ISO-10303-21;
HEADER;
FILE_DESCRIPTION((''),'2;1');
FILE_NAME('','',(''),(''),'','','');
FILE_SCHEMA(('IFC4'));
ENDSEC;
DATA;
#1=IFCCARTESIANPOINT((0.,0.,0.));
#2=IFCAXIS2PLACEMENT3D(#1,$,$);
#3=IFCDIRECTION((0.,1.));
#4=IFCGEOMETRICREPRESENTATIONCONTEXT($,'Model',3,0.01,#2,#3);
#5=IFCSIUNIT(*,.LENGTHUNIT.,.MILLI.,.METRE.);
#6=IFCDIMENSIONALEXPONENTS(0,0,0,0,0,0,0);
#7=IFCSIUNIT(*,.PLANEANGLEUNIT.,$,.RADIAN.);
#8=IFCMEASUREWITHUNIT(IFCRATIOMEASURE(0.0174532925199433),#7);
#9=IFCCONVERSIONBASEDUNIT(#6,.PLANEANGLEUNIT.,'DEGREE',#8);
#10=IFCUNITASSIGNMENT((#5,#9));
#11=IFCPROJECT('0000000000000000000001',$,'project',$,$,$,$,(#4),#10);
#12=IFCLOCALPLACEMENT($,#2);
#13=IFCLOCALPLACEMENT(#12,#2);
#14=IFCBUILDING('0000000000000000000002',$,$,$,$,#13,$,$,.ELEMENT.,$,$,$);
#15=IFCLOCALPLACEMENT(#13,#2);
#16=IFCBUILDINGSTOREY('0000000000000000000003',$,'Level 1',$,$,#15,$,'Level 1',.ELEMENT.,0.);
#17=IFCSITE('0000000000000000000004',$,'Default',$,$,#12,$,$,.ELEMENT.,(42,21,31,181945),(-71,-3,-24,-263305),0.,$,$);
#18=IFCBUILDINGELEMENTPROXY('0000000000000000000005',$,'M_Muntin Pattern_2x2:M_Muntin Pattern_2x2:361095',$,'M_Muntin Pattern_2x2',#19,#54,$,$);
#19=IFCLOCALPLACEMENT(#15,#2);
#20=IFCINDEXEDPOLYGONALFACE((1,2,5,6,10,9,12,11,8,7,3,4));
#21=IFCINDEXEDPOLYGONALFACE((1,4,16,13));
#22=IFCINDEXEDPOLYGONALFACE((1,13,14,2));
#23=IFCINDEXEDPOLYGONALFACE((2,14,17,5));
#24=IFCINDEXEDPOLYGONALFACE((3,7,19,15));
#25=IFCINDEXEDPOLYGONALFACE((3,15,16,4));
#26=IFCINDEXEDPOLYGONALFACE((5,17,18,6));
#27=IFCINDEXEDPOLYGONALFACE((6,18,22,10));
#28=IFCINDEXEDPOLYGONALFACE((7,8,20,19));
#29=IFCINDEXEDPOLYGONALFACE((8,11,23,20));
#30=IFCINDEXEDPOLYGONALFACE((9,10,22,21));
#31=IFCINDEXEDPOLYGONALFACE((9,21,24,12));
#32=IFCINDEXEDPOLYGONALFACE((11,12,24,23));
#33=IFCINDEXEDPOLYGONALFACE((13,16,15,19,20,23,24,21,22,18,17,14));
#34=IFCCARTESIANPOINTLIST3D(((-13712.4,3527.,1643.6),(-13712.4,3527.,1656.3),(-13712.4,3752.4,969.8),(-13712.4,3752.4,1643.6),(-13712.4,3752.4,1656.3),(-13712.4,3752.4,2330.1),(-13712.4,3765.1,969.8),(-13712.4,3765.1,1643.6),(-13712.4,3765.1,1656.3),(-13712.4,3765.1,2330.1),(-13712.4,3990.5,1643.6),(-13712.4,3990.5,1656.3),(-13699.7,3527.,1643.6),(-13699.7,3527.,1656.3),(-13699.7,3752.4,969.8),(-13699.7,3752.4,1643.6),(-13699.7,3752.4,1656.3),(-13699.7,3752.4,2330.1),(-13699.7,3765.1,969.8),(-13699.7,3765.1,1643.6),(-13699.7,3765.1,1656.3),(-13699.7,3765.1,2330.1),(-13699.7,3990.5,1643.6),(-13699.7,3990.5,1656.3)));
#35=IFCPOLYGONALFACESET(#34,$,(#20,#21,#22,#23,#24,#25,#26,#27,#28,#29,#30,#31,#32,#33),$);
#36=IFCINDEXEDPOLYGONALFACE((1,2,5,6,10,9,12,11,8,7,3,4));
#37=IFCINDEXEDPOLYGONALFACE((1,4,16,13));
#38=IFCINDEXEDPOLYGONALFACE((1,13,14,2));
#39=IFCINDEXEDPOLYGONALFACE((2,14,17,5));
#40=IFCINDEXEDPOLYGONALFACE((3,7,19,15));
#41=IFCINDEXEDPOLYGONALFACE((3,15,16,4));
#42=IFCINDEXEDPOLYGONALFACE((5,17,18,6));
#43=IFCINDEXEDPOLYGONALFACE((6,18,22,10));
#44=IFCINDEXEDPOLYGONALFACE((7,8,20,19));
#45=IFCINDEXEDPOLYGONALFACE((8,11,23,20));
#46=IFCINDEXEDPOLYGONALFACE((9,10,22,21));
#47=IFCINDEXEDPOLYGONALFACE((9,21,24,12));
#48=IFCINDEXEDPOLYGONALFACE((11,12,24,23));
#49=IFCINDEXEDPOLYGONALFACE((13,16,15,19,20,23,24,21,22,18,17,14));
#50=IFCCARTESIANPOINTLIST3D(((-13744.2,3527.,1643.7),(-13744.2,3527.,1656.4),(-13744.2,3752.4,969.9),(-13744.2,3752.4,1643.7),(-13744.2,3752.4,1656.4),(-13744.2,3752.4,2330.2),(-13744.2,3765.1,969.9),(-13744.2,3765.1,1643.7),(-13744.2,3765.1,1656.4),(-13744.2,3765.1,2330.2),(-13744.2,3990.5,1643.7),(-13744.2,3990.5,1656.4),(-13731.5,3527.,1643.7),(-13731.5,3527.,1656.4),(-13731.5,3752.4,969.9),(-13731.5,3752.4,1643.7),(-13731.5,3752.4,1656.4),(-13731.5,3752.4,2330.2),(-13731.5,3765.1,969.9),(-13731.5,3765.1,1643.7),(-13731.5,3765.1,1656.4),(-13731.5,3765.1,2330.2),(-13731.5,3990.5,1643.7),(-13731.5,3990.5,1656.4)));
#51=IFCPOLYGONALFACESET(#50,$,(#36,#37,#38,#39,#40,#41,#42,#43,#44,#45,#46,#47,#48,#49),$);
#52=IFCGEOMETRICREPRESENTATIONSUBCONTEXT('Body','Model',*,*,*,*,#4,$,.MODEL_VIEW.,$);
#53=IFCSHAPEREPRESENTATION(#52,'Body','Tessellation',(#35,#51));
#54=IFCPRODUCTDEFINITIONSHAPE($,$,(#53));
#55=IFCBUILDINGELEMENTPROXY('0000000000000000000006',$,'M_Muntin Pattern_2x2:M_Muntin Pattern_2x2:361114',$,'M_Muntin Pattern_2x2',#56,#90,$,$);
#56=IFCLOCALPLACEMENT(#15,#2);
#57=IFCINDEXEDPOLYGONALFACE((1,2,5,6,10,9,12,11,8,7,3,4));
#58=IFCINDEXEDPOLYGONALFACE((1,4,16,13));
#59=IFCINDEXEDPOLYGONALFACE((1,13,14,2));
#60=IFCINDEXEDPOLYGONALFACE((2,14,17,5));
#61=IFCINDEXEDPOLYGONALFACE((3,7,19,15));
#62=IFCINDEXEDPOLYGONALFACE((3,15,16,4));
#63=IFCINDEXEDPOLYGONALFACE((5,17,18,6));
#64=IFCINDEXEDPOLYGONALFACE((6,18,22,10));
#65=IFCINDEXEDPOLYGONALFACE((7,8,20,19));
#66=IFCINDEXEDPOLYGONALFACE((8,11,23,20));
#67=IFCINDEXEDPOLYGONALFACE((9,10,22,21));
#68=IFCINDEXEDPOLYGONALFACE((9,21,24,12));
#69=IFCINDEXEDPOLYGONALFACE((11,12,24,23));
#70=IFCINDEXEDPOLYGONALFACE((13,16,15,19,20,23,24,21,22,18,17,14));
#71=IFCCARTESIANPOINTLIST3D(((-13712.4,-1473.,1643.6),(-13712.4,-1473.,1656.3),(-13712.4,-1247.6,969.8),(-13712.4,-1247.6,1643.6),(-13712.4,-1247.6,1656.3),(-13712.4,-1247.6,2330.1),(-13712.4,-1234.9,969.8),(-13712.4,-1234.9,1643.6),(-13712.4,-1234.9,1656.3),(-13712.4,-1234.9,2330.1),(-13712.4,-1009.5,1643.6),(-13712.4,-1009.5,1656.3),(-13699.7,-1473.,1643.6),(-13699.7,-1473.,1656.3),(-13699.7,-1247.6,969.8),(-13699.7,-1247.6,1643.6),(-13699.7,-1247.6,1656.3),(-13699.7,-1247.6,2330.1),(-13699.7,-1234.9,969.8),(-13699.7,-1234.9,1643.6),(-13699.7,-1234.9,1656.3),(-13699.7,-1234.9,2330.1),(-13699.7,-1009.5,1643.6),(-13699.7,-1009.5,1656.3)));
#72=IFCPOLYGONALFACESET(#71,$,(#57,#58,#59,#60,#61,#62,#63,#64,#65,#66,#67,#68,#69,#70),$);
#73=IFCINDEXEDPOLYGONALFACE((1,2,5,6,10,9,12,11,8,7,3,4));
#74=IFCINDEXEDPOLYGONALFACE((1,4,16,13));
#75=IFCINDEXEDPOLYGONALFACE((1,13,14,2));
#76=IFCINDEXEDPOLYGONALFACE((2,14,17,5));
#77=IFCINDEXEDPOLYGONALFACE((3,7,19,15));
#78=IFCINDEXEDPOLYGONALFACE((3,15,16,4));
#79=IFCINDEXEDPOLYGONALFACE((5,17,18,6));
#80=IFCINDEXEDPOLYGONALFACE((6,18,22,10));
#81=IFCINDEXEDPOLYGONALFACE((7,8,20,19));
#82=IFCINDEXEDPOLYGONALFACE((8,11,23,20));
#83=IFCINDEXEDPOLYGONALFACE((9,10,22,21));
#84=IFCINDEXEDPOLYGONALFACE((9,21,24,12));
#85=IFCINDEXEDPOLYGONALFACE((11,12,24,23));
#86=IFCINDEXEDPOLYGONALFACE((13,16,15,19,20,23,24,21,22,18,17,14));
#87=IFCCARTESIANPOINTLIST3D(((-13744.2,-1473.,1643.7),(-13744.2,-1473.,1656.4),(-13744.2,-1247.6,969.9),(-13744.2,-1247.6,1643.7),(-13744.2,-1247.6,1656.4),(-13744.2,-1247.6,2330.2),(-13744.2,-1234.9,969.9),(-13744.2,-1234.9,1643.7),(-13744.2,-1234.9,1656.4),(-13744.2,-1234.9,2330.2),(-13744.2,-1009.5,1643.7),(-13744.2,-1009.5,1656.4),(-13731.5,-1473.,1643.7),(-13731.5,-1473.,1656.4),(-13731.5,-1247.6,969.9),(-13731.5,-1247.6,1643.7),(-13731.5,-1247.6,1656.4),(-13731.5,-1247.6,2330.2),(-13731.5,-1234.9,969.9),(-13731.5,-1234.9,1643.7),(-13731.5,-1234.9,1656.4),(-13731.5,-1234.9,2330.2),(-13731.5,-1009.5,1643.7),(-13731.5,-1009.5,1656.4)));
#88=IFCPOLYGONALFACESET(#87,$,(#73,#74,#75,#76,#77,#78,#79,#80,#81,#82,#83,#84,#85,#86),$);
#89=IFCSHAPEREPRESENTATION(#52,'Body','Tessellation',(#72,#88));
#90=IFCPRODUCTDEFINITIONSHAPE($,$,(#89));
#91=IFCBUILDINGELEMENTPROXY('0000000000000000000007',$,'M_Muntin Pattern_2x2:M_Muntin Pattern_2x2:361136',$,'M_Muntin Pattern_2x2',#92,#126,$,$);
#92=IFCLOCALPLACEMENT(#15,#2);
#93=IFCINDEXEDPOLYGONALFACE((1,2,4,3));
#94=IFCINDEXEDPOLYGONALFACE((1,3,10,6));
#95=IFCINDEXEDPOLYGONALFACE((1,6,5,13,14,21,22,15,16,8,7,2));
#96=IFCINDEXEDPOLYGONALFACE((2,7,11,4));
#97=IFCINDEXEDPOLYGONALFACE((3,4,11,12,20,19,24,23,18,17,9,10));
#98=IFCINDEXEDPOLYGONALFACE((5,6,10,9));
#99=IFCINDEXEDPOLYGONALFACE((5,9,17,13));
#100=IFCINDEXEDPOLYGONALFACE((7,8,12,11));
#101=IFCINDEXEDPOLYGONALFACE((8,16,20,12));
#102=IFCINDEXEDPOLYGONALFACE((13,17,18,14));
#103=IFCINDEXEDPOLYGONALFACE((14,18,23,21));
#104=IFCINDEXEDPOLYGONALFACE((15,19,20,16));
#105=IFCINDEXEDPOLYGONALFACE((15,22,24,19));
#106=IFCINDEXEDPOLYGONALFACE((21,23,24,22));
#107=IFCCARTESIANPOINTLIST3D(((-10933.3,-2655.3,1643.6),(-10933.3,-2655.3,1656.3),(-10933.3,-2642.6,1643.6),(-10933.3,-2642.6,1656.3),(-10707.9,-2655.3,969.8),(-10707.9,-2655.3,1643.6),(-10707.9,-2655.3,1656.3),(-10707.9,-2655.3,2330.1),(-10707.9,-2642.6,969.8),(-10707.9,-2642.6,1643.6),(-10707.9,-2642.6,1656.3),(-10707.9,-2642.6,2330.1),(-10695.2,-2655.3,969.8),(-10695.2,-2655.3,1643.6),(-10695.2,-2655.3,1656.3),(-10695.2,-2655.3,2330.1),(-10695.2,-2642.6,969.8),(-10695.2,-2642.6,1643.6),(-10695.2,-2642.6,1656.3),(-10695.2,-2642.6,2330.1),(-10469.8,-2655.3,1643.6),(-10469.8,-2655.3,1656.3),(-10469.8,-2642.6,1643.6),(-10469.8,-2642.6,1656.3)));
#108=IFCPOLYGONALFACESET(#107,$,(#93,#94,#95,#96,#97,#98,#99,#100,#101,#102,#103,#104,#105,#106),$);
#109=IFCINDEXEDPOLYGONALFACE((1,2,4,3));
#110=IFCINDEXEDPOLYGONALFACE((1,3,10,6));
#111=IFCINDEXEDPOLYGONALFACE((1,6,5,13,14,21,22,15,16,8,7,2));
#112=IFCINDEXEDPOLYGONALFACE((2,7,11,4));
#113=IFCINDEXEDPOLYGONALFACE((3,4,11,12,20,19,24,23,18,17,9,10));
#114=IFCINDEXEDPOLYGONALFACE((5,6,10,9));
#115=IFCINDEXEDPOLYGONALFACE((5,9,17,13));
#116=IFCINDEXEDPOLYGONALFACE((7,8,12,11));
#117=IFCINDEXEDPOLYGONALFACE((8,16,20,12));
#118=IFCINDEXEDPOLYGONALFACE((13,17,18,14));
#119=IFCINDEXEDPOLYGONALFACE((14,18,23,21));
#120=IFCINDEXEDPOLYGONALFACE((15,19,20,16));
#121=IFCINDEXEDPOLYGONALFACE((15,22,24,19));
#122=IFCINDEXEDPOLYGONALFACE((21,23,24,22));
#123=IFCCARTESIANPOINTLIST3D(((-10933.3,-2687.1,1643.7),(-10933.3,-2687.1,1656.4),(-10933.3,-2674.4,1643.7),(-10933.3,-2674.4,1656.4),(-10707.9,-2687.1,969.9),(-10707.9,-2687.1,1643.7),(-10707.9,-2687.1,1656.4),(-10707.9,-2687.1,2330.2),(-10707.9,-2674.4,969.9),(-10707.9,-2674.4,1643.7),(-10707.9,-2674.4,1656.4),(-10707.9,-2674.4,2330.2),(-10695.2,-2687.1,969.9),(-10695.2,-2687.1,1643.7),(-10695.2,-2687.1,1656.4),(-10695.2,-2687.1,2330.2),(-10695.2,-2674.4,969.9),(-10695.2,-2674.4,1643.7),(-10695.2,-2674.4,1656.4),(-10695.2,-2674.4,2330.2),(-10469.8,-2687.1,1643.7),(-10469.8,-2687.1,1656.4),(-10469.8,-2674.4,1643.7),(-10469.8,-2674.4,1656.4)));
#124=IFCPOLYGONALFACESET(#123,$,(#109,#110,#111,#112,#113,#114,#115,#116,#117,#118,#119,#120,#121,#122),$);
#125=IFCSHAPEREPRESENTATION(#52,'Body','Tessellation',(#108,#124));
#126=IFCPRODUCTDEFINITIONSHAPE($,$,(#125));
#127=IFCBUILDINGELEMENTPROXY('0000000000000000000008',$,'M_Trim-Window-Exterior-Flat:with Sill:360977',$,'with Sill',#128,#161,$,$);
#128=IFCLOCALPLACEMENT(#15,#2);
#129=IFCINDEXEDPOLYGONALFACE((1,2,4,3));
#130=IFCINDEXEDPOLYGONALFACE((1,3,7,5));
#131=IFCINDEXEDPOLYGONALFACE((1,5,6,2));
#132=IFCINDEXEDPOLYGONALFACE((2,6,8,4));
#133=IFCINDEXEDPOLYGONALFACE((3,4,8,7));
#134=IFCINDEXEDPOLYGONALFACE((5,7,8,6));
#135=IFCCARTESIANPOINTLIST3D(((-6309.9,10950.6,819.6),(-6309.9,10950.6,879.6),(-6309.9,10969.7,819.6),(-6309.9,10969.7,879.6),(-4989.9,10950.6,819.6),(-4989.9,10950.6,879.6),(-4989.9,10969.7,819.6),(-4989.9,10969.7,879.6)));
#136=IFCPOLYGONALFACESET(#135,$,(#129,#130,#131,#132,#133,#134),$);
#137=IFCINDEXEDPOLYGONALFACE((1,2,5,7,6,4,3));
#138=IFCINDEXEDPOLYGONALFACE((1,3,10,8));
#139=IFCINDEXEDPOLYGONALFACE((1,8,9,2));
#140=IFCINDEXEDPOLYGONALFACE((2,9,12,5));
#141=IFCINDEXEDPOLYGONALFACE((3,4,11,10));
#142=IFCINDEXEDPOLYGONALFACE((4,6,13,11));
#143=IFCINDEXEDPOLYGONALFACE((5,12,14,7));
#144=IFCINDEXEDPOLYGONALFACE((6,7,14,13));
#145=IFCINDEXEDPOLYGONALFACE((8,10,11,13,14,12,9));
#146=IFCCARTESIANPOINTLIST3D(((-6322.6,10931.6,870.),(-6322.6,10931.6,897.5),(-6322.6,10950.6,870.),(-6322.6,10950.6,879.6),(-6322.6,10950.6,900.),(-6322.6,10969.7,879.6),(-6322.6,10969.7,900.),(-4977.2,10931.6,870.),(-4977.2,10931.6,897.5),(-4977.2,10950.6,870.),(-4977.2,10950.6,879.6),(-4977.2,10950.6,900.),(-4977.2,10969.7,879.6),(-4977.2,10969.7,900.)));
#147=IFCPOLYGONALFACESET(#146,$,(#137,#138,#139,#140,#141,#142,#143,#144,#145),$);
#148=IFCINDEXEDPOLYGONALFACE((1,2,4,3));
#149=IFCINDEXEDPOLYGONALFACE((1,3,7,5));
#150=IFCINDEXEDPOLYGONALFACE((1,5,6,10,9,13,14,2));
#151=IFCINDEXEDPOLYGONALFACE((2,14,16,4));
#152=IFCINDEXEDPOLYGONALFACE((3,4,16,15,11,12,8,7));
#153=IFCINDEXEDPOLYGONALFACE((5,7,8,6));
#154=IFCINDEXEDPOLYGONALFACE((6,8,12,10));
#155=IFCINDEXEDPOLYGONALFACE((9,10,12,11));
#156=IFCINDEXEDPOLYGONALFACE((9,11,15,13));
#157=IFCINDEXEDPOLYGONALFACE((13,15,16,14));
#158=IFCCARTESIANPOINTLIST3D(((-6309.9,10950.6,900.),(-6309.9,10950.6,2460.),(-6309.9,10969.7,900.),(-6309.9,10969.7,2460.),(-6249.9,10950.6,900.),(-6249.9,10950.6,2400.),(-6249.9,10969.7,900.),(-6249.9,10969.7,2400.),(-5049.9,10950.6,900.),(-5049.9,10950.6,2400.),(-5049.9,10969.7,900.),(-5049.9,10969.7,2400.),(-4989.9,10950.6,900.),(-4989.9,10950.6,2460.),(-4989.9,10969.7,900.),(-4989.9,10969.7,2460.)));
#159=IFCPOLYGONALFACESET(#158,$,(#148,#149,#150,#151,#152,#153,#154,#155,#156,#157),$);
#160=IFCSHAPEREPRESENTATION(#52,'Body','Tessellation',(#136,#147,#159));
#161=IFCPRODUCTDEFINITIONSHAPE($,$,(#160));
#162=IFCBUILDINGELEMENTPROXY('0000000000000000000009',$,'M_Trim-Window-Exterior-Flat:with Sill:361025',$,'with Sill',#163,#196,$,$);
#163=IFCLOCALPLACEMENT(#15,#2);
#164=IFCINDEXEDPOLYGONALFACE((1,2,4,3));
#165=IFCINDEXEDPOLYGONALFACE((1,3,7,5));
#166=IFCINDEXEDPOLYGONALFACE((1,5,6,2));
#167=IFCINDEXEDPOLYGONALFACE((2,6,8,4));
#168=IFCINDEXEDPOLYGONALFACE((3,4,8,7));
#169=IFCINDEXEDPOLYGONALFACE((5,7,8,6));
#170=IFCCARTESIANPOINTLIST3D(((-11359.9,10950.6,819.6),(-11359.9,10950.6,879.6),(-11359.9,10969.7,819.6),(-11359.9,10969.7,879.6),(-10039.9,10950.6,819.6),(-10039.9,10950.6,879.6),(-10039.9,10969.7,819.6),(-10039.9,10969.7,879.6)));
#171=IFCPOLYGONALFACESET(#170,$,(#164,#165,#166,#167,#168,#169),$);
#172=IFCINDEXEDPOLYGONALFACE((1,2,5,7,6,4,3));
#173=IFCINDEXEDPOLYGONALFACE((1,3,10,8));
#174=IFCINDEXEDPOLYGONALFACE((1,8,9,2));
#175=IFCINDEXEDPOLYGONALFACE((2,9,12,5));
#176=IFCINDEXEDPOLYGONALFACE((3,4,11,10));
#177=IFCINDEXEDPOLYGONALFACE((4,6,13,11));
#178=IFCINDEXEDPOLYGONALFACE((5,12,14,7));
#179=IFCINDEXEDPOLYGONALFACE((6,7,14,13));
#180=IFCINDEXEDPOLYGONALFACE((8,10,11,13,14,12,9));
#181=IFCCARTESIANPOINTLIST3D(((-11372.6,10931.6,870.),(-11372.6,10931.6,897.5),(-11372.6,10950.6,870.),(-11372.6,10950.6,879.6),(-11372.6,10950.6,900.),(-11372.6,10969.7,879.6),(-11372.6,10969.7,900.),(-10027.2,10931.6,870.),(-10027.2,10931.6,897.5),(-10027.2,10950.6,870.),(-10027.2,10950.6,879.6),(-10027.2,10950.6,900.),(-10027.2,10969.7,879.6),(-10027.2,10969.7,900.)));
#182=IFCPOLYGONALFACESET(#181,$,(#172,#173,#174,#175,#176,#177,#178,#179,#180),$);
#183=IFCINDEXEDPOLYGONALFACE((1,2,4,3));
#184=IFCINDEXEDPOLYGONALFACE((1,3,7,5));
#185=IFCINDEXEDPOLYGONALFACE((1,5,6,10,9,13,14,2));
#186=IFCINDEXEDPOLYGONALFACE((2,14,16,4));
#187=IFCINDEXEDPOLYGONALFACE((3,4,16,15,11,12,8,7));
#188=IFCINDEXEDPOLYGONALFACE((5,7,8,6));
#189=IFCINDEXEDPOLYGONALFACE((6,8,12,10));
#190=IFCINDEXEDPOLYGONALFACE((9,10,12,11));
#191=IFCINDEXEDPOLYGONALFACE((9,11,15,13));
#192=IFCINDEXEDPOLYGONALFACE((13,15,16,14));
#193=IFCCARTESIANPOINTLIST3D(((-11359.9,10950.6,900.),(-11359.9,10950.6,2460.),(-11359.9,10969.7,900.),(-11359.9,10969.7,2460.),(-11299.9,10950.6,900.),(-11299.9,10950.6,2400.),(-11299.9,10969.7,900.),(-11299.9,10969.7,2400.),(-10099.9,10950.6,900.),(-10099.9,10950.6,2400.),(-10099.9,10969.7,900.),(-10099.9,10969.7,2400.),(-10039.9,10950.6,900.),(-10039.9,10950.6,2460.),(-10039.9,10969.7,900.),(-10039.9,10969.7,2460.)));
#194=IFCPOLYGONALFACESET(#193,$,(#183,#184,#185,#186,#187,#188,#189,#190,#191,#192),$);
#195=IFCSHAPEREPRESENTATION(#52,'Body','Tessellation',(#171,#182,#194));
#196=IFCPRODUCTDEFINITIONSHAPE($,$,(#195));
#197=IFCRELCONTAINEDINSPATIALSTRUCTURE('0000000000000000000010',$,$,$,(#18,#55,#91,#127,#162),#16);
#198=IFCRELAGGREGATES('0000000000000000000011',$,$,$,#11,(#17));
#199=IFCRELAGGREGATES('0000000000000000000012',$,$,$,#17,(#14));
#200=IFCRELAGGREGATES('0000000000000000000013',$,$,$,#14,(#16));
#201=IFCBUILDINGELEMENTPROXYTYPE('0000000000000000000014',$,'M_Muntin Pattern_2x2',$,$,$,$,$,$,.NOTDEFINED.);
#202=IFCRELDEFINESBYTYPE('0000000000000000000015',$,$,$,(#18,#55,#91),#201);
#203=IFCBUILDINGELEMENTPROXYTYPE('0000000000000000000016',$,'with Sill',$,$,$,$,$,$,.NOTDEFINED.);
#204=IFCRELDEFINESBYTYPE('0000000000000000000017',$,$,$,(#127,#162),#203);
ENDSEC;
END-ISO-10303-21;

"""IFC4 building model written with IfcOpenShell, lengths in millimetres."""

from ifc_helpers import new_model, entity, si_unit, converted_unit, direction, frame, frame_2d, origin, place, context, subcontext, project, spatial, polyline, rectangle, outline, extrude, source, transform, mapped, type_object, type_shapes, element, save


model = new_model("IFC4")

# Units and contexts
model_context = context("Model", 3, precision=0.01, world=origin(), true_north=direction((0.0, 1.0)))
body_context = subcontext(model_context, "Body", "Model", "MODEL_VIEW")
ifc_project = project(units=[si_unit("LENGTHUNIT", "METRE", prefix="MILLI"), converted_unit("PLANEANGLEUNIT", "DEGREE", entity("IfcRatioMeasure", 0.0174532925199433), si_unit("PLANEANGLEUNIT", "RADIAN"), dimensions=[0, 0, 0, 0, 0, 0, 0])], contexts=[model_context])

# Site, building, storey
site_placement = place(None, origin())
site = spatial("IfcSite", under=ifc_project, at=site_placement, Name="Default", CompositionType="ELEMENT", RefLatitude=(42, 21, 31, 181945), RefLongitude=(-71, -3, -24, -263305), RefElevation=0.0)
building_placement = place(site_placement, origin())
building = spatial("IfcBuilding", under=site, at=building_placement, CompositionType="ELEMENT")
storey_placement = place(building_placement, origin())
storey = spatial("IfcBuildingStorey", under=building, at=storey_placement, Name="Level 1", LongName="Level 1", CompositionType="ELEMENT", Elevation=0.0)

# Building element proxies
building_element_proxy_type_1 = type_object("IfcBuildingElementProxyType", Name="M_Muntin Pattern_2x2", PredefinedType="NOTDEFINED")
shared_shape_1 = source(origin(), body_context, "Body", "SweptSolid", [
    extrude(outline(polyline([(6.4, -6.4), (680.1, -6.4), (680.1, 6.3), (6.4, 6.3), (6.4, 231.7), (-6.3, 231.7), (-6.3, 6.3), (-680.2, 6.3), (-680.2, -6.4), (-6.3, -6.4), (-6.3, -231.7), (6.4, -231.7), (6.4, -6.4)])), frame((0.0, -22.2, 680.1), z_axis=(0.0, 1.0, 0.0), x_axis=(0.0, 0.0, 1.0)), (0.0, 0.0, 1.0), 12.7),
    extrude(outline(polyline([(6.4, -6.4), (680.1, -6.4), (680.1, 6.3), (6.4, 6.3), (6.4, 231.7), (-6.3, 231.7), (-6.3, 6.3), (-680.2, 6.3), (-680.2, -6.4), (-6.3, -6.4), (-6.3, -231.7), (6.4, -231.7), (6.4, -6.4)])), frame((0.0, 9.5, 680.2), z_axis=(0.0, 1.0, 0.0), x_axis=(0.0, 0.0, 1.0)), (0.0, 0.0, 1.0), 12.7),
])
type_shapes(building_element_proxy_type_1, [shared_shape_1])
for number, where, z_axis, x_axis, name in (
    (1, (-13722.0, 3758.7, 969.9), (0.0, 0.0, 1.0), (0.0, 1.0, 0.0), "M_Muntin Pattern_2x2:M_Muntin Pattern_2x2:361095"),
    (2, (-13722.0, -1241.3, 969.9), (0.0, 0.0, 1.0), (0.0, 1.0, 0.0), "M_Muntin Pattern_2x2:M_Muntin Pattern_2x2:361114"),
    (3, (-10701.5, -2664.9, 969.9), (0.0, 0.0, 1.0), (-1.0, 0.0, 0.0), "M_Muntin Pattern_2x2:M_Muntin Pattern_2x2:361136"),
):
    element("IfcBuildingElementProxy", number, at=place(storey_placement, frame(where, z_axis=z_axis, x_axis=x_axis)), inside=storey, type_object=building_element_proxy_type_1, Name=name, ObjectType="M_Muntin Pattern_2x2", context=body_context, shape_type="MappedRepresentation", body=[
        mapped(shared_shape_1, transform((0.0, 0.0, 0.0), scale=1.0)),
    ])
building_element_proxy_type_2 = type_object("IfcBuildingElementProxyType", Name="with Sill", PredefinedType="NOTDEFINED")
shared_shape_2 = source(origin(), body_context, "Body", "SweptSolid", [
    extrude(rectangle(XDim=1320.0, YDim=60.0, at=frame_2d((0.0, 0.0), x_axis=(1.0, 0.0))), frame((0.0, -1550.4, 0.0), z_axis=(0.0, 0.0, 1.0), x_axis=(-1.0, 0.0, 0.0)), (0.0, 0.0, 1.0), 19.1),
    extrude(outline(polyline([(-19.0, -15.2), (0.0, -15.2), (0.0, -5.7), (19.0, -5.7), (19.0, 14.8), (0.0, 14.8), (-19.0, 12.3), (-19.0, -15.2)])), frame((-672.7, -1514.8, 19.0), z_axis=(1.0, 0.0, 0.0), x_axis=(0.0, 0.0, -1.0)), (0.0, 0.0, 1.0), 1345.4),
    extrude(outline(polyline([(-795.0, -660.0), (765.0, -660.0), (765.0, -600.0), (-735.0, -600.0), (-735.0, 600.0), (765.0, 600.0), (765.0, 660.0), (-795.0, 660.0), (-795.0, -660.0)])), frame((0.0, -735.0, 0.0), z_axis=(0.0, 0.0, 1.0), x_axis=(0.0, -1.0, 0.0)), (0.0, 0.0, 1.0), 19.1),
])
type_shapes(building_element_proxy_type_2, [shared_shape_2])
for number, where, z_axis, x_axis, name in (
    (4, (-5649.9, 10969.7, 2400.0), (0.0, -1.0, 0.0), (1.0, 0.0, 0.0), "M_Trim-Window-Exterior-Flat:with Sill:360977"),
    (5, (-10699.9, 10969.7, 2400.0), (0.0, -1.0, 0.0), (1.0, 0.0, 0.0), "M_Trim-Window-Exterior-Flat:with Sill:361025"),
):
    element("IfcBuildingElementProxy", number, at=place(storey_placement, frame(where, z_axis=z_axis, x_axis=x_axis)), inside=storey, type_object=building_element_proxy_type_2, Name=name, ObjectType="with Sill", context=body_context, shape_type="MappedRepresentation", body=[
        mapped(shared_shape_2, transform((0.0, 0.0, 0.0), scale=1.0)),
    ])

save(model, "model.ifc")
